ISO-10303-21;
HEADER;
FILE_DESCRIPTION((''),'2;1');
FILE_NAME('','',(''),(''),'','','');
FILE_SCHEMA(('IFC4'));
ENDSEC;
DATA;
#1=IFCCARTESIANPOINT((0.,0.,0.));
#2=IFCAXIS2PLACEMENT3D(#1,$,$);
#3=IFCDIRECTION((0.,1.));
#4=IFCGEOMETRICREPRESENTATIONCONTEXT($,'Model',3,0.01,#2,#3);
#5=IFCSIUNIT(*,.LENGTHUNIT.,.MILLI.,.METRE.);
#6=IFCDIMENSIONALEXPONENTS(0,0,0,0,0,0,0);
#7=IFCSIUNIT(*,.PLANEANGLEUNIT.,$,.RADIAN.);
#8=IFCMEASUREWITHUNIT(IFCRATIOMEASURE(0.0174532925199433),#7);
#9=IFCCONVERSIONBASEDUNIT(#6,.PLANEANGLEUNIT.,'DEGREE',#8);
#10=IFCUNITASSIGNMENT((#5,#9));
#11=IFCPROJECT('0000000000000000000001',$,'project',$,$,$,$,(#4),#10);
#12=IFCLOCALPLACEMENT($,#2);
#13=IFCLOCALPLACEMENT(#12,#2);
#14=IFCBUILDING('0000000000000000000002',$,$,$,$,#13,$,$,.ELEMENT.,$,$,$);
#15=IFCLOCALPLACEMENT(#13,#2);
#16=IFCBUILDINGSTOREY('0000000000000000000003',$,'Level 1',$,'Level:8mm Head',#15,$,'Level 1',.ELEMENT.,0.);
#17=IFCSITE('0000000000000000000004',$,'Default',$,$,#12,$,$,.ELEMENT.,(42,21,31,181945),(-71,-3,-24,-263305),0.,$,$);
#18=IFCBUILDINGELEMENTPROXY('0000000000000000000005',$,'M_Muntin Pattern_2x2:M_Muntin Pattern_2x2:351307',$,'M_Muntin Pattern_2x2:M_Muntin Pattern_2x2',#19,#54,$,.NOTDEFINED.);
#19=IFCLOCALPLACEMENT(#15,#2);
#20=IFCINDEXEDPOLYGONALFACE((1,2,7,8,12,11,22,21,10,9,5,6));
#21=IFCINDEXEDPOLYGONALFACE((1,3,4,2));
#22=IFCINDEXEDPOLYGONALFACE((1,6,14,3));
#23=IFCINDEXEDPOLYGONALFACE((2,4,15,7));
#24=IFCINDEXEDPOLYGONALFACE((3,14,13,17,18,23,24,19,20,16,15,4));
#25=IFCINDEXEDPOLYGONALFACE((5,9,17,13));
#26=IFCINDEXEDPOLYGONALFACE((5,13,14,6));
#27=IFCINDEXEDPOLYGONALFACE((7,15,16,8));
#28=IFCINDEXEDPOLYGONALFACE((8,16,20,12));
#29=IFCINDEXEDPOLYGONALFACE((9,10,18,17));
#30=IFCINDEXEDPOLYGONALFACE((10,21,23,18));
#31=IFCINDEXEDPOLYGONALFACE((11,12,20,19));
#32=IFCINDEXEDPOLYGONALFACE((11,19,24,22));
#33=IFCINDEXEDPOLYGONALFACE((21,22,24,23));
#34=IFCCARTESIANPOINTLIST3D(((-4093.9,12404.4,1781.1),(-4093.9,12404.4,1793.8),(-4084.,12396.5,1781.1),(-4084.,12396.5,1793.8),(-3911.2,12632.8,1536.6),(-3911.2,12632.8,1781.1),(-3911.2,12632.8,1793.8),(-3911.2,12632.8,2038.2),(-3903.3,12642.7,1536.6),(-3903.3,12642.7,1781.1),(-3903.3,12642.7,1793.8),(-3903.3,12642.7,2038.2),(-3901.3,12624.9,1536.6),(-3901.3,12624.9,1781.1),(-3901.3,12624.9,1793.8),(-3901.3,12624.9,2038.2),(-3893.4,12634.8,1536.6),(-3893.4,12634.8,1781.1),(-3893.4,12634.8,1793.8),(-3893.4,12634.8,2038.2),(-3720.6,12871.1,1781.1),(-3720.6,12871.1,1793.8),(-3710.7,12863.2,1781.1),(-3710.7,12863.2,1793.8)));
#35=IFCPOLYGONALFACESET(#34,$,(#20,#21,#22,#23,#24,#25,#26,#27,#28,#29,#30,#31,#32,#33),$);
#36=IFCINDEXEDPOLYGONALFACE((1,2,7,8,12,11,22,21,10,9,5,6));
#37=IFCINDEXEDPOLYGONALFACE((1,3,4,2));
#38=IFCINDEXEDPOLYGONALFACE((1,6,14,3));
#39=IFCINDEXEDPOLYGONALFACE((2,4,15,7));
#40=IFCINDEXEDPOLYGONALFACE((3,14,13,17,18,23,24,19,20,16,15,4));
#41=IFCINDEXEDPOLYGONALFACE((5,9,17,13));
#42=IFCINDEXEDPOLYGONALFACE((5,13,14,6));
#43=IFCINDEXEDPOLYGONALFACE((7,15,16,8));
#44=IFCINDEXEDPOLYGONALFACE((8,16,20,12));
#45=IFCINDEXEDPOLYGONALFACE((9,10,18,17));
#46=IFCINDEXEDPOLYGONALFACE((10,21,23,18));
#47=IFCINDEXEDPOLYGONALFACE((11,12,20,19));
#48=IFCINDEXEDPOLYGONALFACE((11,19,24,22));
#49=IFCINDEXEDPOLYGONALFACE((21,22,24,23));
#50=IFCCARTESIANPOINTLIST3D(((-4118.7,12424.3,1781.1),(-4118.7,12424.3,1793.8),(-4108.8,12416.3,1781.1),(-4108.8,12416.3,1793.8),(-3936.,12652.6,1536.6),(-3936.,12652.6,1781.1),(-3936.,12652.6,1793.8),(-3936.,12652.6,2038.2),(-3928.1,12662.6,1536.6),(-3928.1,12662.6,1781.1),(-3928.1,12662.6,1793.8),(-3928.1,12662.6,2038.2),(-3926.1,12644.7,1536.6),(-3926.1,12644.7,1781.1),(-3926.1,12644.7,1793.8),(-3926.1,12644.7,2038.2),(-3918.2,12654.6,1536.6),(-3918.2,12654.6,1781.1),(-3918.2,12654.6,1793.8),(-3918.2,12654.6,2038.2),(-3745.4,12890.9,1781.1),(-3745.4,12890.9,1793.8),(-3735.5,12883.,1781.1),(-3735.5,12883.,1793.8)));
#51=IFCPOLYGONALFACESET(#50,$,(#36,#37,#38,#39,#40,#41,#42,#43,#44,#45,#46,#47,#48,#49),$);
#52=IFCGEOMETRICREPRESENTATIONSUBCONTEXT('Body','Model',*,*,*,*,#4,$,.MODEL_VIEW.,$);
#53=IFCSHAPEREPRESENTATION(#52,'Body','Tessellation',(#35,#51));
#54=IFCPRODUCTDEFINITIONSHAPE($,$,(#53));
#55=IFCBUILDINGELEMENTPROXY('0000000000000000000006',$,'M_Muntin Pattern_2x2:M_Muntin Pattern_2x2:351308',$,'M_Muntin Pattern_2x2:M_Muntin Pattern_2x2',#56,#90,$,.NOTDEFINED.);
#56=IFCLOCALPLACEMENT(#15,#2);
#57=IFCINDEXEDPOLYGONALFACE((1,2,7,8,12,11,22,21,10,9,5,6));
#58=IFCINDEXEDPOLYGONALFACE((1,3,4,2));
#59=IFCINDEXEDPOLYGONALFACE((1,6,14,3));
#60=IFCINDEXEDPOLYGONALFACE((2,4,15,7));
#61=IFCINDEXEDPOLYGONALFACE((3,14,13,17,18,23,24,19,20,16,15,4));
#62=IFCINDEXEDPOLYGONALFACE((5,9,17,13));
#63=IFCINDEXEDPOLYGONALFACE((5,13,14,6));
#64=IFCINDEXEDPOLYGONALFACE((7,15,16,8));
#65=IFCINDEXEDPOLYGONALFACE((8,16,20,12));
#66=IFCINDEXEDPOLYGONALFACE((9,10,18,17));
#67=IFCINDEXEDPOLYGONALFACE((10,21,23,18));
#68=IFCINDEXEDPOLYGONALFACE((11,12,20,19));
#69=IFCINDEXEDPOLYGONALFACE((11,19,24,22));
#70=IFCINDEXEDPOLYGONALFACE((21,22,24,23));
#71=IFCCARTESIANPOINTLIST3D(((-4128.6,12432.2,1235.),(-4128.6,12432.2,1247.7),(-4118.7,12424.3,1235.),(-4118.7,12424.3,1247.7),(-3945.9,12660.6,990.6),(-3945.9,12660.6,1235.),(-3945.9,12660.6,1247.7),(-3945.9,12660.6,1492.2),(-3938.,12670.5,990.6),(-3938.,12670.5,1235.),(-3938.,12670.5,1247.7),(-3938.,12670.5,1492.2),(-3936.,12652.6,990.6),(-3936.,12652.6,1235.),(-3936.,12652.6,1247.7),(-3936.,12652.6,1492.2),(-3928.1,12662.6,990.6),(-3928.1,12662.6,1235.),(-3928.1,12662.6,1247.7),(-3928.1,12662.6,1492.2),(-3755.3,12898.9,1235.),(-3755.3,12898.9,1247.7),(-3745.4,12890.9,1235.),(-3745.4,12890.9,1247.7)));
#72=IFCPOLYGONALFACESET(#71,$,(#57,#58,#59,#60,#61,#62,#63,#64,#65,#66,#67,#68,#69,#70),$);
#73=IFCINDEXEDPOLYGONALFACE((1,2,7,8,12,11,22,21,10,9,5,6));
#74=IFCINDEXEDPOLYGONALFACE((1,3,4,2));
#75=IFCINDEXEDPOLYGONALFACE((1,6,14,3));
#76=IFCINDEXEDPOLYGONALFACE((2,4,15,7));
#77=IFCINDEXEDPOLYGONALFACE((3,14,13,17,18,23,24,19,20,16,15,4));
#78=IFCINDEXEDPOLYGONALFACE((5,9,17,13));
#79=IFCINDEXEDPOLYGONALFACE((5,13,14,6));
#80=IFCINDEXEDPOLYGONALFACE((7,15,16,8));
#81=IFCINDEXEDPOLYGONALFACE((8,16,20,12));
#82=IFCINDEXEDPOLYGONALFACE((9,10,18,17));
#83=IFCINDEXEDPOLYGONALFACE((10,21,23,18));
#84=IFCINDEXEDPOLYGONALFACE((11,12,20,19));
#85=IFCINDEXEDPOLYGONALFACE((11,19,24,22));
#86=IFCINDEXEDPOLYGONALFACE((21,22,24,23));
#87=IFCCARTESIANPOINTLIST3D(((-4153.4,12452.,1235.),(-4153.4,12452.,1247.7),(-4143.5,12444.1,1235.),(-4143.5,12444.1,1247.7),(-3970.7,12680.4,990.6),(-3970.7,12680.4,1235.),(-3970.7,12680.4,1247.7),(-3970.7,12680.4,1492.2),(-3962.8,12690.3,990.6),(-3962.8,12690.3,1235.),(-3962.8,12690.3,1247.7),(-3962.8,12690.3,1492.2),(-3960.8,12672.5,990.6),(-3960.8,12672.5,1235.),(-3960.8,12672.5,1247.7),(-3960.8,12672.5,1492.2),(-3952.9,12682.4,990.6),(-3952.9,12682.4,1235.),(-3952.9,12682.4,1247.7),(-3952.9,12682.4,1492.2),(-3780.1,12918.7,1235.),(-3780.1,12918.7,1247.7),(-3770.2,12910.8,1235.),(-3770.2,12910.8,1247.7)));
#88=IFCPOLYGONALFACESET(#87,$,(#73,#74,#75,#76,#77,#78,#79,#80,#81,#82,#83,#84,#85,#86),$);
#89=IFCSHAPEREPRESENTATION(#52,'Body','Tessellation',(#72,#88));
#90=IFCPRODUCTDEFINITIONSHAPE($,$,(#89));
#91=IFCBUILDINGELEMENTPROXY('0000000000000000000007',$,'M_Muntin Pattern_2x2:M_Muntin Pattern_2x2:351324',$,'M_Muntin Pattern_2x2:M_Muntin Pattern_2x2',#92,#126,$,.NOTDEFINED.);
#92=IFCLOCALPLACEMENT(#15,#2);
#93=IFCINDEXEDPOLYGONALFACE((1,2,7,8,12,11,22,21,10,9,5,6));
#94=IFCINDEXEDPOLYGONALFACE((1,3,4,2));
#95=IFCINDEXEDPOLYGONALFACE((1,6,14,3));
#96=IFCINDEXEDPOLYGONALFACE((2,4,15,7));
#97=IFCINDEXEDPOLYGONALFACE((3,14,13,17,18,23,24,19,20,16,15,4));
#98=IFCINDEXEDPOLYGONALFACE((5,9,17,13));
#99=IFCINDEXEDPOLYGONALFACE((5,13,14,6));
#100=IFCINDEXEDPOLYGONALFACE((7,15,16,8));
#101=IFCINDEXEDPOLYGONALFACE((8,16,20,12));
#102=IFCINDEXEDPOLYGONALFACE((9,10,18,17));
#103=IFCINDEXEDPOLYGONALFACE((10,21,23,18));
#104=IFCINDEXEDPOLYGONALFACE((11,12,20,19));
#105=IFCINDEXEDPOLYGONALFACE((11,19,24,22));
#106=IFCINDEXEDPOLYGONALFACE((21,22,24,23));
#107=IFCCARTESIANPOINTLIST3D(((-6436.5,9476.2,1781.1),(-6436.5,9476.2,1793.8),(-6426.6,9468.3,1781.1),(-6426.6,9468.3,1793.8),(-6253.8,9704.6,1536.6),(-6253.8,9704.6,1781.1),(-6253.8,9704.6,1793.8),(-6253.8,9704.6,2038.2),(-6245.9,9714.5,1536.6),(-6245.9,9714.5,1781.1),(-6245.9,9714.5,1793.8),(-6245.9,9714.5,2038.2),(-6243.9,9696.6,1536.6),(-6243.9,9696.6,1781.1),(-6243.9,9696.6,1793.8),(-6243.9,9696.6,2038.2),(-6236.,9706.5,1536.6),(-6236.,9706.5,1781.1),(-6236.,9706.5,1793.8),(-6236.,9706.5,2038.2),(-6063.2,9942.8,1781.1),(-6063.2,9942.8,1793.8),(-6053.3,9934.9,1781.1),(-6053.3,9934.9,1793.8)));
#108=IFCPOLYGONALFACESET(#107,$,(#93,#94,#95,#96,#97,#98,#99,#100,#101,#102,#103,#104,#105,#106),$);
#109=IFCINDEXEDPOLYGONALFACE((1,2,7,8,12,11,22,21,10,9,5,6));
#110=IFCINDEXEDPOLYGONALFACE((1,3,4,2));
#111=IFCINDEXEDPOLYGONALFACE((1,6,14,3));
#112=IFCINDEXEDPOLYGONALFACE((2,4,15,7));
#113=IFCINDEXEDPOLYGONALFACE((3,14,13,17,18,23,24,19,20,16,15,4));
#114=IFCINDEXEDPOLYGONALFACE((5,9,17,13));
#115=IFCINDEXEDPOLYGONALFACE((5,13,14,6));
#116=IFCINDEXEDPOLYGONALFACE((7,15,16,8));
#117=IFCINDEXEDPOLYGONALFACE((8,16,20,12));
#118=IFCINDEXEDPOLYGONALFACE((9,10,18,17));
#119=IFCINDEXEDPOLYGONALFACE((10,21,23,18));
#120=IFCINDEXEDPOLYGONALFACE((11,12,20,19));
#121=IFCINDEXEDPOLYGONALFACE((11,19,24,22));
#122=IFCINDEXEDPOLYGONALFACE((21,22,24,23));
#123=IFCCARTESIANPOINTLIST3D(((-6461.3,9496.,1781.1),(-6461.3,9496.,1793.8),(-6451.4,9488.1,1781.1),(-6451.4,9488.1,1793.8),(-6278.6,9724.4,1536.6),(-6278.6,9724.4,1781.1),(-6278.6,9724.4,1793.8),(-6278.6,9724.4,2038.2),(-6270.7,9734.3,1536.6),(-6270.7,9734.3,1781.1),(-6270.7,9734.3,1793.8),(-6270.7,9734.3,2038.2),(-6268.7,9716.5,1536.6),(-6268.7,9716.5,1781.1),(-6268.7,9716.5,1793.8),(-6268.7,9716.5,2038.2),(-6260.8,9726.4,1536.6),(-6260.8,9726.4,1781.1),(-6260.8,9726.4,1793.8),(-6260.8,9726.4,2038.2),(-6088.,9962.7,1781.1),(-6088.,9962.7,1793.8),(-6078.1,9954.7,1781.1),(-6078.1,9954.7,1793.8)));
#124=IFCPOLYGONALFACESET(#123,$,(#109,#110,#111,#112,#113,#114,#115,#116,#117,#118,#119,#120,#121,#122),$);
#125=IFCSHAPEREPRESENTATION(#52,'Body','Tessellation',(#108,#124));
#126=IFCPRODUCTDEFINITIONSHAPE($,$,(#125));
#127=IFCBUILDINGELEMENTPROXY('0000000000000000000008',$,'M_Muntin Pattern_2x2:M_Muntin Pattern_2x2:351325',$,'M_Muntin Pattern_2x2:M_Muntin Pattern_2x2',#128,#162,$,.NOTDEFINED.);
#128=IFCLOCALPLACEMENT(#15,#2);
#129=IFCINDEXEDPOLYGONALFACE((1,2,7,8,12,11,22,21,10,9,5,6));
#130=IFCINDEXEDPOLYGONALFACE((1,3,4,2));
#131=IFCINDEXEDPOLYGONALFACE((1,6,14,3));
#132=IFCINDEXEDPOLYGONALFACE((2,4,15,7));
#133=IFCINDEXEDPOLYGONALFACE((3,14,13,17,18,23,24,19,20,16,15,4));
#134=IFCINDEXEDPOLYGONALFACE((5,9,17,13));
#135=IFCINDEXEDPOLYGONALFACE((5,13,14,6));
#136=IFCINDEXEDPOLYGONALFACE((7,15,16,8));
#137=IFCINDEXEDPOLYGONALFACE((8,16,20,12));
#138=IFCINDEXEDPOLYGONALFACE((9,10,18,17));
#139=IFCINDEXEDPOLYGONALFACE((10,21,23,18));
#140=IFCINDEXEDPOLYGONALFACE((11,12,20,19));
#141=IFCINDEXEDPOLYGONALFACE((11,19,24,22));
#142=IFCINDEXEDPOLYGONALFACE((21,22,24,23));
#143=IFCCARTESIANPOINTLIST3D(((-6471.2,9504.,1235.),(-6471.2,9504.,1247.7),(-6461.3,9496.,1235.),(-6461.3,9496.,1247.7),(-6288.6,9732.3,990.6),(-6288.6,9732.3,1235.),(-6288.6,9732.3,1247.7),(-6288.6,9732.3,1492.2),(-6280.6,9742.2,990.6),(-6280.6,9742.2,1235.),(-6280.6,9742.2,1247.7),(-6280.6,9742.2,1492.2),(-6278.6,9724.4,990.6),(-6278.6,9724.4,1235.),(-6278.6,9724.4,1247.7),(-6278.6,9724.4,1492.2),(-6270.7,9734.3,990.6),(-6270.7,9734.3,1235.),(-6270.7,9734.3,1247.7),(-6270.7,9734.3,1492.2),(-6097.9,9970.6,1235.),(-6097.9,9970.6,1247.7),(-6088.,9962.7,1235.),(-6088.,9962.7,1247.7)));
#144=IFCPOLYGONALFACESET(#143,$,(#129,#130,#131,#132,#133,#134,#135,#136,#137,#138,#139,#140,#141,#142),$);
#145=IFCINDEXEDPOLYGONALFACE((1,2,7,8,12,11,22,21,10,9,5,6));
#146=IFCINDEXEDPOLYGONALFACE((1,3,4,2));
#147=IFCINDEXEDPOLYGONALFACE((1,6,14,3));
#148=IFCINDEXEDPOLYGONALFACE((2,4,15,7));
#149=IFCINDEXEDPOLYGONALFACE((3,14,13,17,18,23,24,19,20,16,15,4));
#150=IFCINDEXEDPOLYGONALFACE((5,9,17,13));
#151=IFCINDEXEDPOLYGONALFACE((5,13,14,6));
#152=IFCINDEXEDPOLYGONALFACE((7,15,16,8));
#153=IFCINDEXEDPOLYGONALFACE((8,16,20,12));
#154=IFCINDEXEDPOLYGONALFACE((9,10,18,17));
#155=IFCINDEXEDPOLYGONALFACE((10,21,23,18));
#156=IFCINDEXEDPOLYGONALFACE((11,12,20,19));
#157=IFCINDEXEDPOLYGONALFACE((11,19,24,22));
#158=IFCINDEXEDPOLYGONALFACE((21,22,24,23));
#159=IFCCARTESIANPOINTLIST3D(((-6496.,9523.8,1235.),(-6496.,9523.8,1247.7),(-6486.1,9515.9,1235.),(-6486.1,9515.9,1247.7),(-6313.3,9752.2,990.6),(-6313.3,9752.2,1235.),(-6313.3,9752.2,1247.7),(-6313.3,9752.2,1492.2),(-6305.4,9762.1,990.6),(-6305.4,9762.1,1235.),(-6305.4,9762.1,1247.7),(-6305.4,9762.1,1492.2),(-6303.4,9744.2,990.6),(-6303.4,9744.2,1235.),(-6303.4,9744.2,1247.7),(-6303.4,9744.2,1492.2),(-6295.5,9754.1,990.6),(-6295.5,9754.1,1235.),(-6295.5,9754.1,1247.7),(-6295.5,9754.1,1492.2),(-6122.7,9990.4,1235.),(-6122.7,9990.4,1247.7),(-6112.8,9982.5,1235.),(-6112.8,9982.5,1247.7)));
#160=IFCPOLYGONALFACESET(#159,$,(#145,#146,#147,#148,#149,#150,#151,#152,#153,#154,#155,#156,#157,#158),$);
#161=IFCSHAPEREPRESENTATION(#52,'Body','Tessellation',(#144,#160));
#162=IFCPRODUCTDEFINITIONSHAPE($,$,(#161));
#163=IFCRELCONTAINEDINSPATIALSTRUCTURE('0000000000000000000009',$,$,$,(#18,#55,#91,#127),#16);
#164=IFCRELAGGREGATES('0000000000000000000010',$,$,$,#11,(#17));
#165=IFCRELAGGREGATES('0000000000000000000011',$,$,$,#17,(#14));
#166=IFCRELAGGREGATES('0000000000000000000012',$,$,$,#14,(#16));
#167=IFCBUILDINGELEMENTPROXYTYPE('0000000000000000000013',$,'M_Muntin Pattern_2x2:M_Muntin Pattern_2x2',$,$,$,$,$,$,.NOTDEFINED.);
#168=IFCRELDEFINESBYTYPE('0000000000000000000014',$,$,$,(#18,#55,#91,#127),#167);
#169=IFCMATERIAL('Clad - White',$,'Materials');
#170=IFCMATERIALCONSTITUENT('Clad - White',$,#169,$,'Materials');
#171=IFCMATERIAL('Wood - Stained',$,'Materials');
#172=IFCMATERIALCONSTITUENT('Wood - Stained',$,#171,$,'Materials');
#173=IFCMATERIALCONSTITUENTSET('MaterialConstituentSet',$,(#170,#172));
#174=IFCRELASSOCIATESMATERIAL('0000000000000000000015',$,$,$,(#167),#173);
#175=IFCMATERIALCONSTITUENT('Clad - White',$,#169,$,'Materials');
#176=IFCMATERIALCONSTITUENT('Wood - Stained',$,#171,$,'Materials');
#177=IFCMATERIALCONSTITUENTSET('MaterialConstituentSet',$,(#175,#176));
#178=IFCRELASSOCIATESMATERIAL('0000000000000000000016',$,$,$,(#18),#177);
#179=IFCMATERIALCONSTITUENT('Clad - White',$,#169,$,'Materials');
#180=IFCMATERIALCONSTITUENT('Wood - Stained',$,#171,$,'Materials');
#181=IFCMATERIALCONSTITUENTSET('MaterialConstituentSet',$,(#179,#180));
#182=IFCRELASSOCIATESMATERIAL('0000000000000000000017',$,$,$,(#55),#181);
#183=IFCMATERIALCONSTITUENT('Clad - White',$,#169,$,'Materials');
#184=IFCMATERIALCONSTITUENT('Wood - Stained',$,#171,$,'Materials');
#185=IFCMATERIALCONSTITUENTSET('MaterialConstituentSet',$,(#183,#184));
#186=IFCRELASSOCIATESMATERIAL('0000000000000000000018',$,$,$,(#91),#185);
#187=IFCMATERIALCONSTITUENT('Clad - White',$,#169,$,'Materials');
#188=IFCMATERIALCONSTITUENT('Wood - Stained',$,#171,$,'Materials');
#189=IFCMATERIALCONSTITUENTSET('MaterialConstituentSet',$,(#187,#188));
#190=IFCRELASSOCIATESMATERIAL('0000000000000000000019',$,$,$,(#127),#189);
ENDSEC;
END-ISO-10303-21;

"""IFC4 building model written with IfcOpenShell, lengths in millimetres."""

from ifc_helpers import new_model, entity, si_unit, converted_unit, direction, frame, origin, place, context, subcontext, project, spatial, polyline, outline, extrude, source, transform, mapped, material, constituent, constituent_set, type_object, type_shapes, element, save


model = new_model("IFC4")

# Units and contexts
model_context = context("Model", 3, precision=0.01, world=origin(), true_north=direction((0.0, 1.0)))
body_context = subcontext(model_context, "Body", "Model", "MODEL_VIEW")
ifc_project = project(units=[si_unit("LENGTHUNIT", "METRE", prefix="MILLI"), converted_unit("PLANEANGLEUNIT", "DEGREE", entity("IfcRatioMeasure", 0.0174532925199433), si_unit("PLANEANGLEUNIT", "RADIAN"), dimensions=[0, 0, 0, 0, 0, 0, 0])], contexts=[model_context])

# Site, building, storey
site_placement = place(None, origin())
site = spatial("IfcSite", under=ifc_project, at=site_placement, Name="Default", CompositionType="ELEMENT", RefLatitude=(42, 21, 31, 181945), RefLongitude=(-71, -3, -24, -263305), RefElevation=0.0)
building_placement = place(site_placement, origin())
building = spatial("IfcBuilding", under=site, at=building_placement, CompositionType="ELEMENT")
storey_placement = place(building_placement, origin())
storey = spatial("IfcBuildingStorey", under=building, at=storey_placement, Name="Level 1", ObjectType="Level:8mm Head", LongName="Level 1", CompositionType="ELEMENT", Elevation=0.0)

# Shared definitions
ifc_material_1 = material(Name="Wood - Stained", Category="Materials")

# Building element proxies
ifc_material_2 = material(Name="Clad - White", Category="Materials")
ifc_constituent_1 = constituent(ifc_material_2, Name="Clad - White", Category="Materials")
ifc_constituent_2 = constituent(ifc_material_1, Name="Wood - Stained", Category="Materials")
ifc_constituent_set_1 = constituent_set(constituents=[ifc_constituent_1, ifc_constituent_2], Name="MaterialConstituentSet")
building_element_proxy_type_1 = type_object("IfcBuildingElementProxyType", Name="M_Muntin Pattern_2x2:M_Muntin Pattern_2x2", PredefinedType="NOTDEFINED", material=ifc_constituent_set_1)
shared_shape_1 = source(origin(), body_context, "Body", "SweptSolid", [
    extrude(outline(polyline([(6.4, -6.4), (250.8, -6.4), (250.8, 6.3), (6.4, 6.3), (6.4, 298.8), (-6.3, 298.8), (-6.3, 6.3), (-250.8, 6.3), (-250.8, -6.4), (-6.3, -6.4), (-6.3, -298.8), (6.4, -298.8), (6.4, -6.4)])), frame((0.0, 9.5, 250.8), z_axis=(0.0, 1.0, 0.0), x_axis=(0.0, 0.0, 1.0)), (0.0, 0.0, 1.0), 12.7),
    extrude(outline(polyline([(6.4, -6.4), (250.8, -6.4), (250.8, 6.3), (6.4, 6.3), (6.4, 298.8), (-6.3, 298.8), (-6.3, 6.3), (-250.8, 6.3), (-250.8, -6.4), (-6.3, -6.4), (-6.3, -298.8), (6.4, -298.8), (6.4, -6.4)])), frame((0.0, -22.2, 250.8), z_axis=(0.0, 1.0, 0.0), x_axis=(0.0, 0.0, 1.0)), (0.0, 0.0, 1.0), 12.7),
])
type_shapes(building_element_proxy_type_1, [shared_shape_1])
ifc_constituent_3 = constituent(ifc_material_2, Name="Clad - White", Category="Materials")
ifc_constituent_4 = constituent(ifc_material_1, Name="Wood - Stained", Category="Materials")
ifc_constituent_set_2 = constituent_set(constituents=[ifc_constituent_3, ifc_constituent_4], Name="MaterialConstituentSet")
proxy_1_placement = place(storey_placement, frame((-3914.7, 12643.7, 1536.6), z_axis=(0.0, 0.0, 1.0), x_axis=(-0.624695, -0.780869, 0.0)))
element("IfcBuildingElementProxy", 1, at=proxy_1_placement, inside=storey, type_object=building_element_proxy_type_1, material=ifc_constituent_set_2, Name="M_Muntin Pattern_2x2:M_Muntin Pattern_2x2:351307", ObjectType="M_Muntin Pattern_2x2:M_Muntin Pattern_2x2", PredefinedType="NOTDEFINED", context=body_context, shape_type="MappedRepresentation", body=[
    mapped(shared_shape_1, transform((0.0, 0.0, 0.0), scale=1.0)),
])
ifc_constituent_5 = constituent(ifc_material_2, Name="Clad - White", Category="Materials")
ifc_constituent_6 = constituent(ifc_material_1, Name="Wood - Stained", Category="Materials")
ifc_constituent_set_3 = constituent_set(constituents=[ifc_constituent_5, ifc_constituent_6], Name="MaterialConstituentSet")
proxy_2_placement = place(storey_placement, frame((-3949.4, 12671.5, 990.6), z_axis=(0.0, 0.0, 1.0), x_axis=(-0.624695, -0.780869, 0.0)))
element("IfcBuildingElementProxy", 2, at=proxy_2_placement, inside=storey, type_object=building_element_proxy_type_1, material=ifc_constituent_set_3, Name="M_Muntin Pattern_2x2:M_Muntin Pattern_2x2:351308", ObjectType="M_Muntin Pattern_2x2:M_Muntin Pattern_2x2", PredefinedType="NOTDEFINED", context=body_context, shape_type="MappedRepresentation", body=[
    mapped(shared_shape_1, transform((0.0, 0.0, 0.0), scale=1.0)),
])
ifc_constituent_7 = constituent(ifc_material_2, Name="Clad - White", Category="Materials")
ifc_constituent_8 = constituent(ifc_material_1, Name="Wood - Stained", Category="Materials")
ifc_constituent_set_4 = constituent_set(constituents=[ifc_constituent_7, ifc_constituent_8], Name="MaterialConstituentSet")
proxy_3_placement = place(storey_placement, frame((-6257.3, 9715.5, 1536.6), z_axis=(0.0, 0.0, 1.0), x_axis=(-0.624695, -0.780869, 0.0)))
element("IfcBuildingElementProxy", 3, at=proxy_3_placement, inside=storey, type_object=building_element_proxy_type_1, material=ifc_constituent_set_4, Name="M_Muntin Pattern_2x2:M_Muntin Pattern_2x2:351324", ObjectType="M_Muntin Pattern_2x2:M_Muntin Pattern_2x2", PredefinedType="NOTDEFINED", context=body_context, shape_type="MappedRepresentation", body=[
    mapped(shared_shape_1, transform((0.0, 0.0, 0.0), scale=1.0)),
])
ifc_constituent_9 = constituent(ifc_material_2, Name="Clad - White", Category="Materials")
ifc_constituent_10 = constituent(ifc_material_1, Name="Wood - Stained", Category="Materials")
ifc_constituent_set_5 = constituent_set(constituents=[ifc_constituent_9, ifc_constituent_10], Name="MaterialConstituentSet")
proxy_4_placement = place(storey_placement, frame((-6292.0, 9743.2, 990.6), z_axis=(0.0, 0.0, 1.0), x_axis=(-0.624695, -0.780869, 0.0)))
element("IfcBuildingElementProxy", 4, at=proxy_4_placement, inside=storey, type_object=building_element_proxy_type_1, material=ifc_constituent_set_5, Name="M_Muntin Pattern_2x2:M_Muntin Pattern_2x2:351325", ObjectType="M_Muntin Pattern_2x2:M_Muntin Pattern_2x2", PredefinedType="NOTDEFINED", context=body_context, shape_type="MappedRepresentation", body=[
    mapped(shared_shape_1, transform((0.0, 0.0, 0.0), scale=1.0)),
])

save(model, "model.ifc")
